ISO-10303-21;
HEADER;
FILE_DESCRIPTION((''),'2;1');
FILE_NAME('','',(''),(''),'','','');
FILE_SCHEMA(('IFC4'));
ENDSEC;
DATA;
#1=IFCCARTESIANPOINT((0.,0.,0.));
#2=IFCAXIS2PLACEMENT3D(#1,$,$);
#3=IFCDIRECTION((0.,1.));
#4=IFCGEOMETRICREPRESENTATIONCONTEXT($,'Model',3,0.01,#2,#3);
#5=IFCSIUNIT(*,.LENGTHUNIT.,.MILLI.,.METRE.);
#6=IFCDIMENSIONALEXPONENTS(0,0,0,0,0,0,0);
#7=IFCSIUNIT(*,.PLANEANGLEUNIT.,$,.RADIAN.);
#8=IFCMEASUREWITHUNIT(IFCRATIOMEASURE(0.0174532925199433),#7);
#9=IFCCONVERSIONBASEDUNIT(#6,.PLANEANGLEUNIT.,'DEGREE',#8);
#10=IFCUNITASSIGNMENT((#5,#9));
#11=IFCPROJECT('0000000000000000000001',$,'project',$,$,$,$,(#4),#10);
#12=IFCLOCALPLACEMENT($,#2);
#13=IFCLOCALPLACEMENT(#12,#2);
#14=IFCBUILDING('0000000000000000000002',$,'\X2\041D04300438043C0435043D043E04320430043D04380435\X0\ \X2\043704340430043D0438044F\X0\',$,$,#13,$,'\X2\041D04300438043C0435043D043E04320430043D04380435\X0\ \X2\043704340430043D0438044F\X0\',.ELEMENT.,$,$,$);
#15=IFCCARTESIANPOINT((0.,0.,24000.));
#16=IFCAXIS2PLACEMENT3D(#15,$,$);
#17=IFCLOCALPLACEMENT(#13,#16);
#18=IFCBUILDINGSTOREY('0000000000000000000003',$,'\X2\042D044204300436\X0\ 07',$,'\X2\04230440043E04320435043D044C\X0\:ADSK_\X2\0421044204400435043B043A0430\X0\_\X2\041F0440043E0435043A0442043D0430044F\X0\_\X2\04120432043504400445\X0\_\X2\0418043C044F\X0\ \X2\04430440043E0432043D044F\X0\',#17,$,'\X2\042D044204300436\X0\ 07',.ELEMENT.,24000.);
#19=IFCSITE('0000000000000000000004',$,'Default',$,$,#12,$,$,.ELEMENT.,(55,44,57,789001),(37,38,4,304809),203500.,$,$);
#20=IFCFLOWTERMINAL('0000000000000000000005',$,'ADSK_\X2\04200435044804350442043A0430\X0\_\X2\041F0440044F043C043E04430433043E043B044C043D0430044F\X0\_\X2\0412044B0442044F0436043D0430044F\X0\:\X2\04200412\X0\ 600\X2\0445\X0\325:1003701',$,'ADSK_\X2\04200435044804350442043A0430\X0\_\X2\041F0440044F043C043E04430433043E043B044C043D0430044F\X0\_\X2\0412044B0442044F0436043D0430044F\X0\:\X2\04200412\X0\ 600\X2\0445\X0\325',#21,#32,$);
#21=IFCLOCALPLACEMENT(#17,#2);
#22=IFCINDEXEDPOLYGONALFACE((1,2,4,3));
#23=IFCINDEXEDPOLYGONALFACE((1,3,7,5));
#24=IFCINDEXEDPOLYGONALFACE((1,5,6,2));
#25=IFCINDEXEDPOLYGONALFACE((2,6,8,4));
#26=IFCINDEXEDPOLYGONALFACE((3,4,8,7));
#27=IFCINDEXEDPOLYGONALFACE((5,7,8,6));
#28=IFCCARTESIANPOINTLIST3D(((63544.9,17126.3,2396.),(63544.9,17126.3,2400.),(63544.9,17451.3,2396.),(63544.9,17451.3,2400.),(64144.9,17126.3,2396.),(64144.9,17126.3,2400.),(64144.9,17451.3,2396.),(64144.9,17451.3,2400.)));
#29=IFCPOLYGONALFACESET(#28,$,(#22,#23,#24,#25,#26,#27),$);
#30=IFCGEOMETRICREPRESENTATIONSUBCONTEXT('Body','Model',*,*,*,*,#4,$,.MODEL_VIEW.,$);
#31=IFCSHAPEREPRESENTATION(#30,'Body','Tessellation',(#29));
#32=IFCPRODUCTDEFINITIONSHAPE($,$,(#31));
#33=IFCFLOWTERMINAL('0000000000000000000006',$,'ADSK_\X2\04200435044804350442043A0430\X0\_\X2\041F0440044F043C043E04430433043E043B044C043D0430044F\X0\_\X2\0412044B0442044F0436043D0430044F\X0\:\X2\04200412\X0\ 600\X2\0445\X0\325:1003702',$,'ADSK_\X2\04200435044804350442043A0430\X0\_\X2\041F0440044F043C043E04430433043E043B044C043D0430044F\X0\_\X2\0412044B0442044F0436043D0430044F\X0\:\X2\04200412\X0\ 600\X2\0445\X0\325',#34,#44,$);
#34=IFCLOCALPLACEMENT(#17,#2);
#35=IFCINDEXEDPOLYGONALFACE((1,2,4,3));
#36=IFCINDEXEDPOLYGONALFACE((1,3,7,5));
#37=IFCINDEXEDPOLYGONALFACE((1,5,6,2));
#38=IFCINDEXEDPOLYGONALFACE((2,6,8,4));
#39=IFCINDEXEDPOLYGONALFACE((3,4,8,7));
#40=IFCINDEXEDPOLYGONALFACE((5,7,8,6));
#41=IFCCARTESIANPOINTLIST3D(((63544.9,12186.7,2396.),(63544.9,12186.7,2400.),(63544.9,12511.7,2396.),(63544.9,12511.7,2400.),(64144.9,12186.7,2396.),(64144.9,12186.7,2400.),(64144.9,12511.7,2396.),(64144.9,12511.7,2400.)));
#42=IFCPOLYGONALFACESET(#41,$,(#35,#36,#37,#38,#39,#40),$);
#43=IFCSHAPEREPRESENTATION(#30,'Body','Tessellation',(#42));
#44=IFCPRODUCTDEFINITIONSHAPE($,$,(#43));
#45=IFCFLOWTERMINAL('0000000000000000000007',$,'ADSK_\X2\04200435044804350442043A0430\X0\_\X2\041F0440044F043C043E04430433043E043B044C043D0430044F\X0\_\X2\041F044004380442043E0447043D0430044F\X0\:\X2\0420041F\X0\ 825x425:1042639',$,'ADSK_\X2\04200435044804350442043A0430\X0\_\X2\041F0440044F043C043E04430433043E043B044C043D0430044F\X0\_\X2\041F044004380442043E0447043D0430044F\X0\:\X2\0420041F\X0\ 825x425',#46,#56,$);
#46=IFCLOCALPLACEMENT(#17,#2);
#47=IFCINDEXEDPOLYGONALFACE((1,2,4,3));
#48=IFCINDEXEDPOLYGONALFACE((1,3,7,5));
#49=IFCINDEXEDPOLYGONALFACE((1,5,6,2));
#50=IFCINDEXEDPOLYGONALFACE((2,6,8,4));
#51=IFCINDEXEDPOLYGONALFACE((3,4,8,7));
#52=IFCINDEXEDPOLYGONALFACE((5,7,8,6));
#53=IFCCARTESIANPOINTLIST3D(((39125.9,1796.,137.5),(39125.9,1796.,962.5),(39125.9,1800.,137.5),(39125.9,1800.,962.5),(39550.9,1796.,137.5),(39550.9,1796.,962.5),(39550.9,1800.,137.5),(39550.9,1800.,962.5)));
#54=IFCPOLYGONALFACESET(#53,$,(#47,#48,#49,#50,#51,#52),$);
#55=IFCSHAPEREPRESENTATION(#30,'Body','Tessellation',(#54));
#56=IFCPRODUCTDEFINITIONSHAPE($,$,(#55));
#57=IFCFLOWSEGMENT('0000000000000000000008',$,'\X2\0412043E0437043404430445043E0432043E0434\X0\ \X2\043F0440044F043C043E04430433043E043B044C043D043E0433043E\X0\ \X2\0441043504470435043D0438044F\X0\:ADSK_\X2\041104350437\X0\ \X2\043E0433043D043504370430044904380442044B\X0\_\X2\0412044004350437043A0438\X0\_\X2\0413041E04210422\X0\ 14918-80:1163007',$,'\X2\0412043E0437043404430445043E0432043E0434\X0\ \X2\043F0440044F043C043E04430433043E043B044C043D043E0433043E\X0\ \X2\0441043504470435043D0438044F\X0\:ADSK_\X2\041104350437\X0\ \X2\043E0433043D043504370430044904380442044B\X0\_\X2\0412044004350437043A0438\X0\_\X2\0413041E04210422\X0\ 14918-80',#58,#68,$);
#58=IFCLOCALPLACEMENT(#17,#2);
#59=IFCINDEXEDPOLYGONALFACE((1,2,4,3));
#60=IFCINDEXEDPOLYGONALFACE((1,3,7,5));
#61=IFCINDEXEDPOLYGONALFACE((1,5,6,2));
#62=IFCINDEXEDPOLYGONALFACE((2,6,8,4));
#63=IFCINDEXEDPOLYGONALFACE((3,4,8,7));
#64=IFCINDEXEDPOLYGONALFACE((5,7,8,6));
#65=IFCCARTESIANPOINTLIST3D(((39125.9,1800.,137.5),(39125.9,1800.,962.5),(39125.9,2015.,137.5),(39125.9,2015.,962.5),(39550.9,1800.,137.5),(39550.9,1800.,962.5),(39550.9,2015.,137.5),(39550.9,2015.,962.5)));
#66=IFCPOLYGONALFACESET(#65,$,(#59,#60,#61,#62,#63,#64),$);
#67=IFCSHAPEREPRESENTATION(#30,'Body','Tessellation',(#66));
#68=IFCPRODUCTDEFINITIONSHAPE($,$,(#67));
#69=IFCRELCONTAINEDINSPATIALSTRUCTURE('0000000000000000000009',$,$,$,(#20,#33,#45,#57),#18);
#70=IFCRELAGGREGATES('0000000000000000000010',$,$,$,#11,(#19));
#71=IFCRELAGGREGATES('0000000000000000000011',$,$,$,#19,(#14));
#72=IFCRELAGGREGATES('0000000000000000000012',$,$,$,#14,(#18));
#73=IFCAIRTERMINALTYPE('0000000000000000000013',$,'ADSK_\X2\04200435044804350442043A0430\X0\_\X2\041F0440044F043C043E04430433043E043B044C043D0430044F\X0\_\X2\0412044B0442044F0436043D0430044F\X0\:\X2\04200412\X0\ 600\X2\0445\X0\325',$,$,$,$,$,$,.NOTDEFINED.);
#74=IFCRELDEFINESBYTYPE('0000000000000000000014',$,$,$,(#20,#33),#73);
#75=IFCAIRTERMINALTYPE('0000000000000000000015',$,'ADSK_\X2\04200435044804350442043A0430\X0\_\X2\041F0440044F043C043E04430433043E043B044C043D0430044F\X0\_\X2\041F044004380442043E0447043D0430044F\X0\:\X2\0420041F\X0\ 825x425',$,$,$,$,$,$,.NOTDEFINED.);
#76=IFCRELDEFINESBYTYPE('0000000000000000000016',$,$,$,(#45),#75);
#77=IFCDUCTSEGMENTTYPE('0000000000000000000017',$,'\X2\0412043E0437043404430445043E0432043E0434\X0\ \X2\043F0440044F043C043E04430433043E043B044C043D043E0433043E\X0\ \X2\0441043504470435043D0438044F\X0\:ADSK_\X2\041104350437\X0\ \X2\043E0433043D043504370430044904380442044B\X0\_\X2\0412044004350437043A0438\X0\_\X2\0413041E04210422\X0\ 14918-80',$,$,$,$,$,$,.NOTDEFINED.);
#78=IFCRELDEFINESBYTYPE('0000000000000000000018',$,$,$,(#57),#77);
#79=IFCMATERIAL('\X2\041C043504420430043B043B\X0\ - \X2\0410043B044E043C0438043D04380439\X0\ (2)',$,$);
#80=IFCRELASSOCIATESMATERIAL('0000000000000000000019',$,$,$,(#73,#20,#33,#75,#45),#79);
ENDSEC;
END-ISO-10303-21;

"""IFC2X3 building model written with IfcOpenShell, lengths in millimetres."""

from ifc_helpers import new_model, entity, si_unit, converted_unit, direction, frame, frame_2d, origin, origin_2d_with_axis, place, context, subcontext, project, spatial, rectangle, extrude, source, transform, mapped, material, type_object, type_shapes, element, save


model = new_model("IFC2X3")

# Units and contexts
model_context = context("Model", 3, precision=0.01, world=origin(), true_north=direction((0.0, 1.0)))
body_context = subcontext(model_context, "Body", "Model", "MODEL_VIEW")
ifc_project = project(units=[si_unit("LENGTHUNIT", "METRE", prefix="MILLI"), converted_unit("PLANEANGLEUNIT", "DEGREE", entity("IfcRatioMeasure", 0.0174532925199433), si_unit("PLANEANGLEUNIT", "RADIAN"), dimensions=[0, 0, 0, 0, 0, 0, 0])], contexts=[model_context])

# Site, building, storey
site_placement = place(None, frame((0.0, 0.0, 0.0)))
site = spatial("IfcSite", under=ifc_project, at=site_placement, Name="Default", CompositionType="ELEMENT", RefLatitude=(55, 44, 57, 789001), RefLongitude=(37, 38, 4, 304809), RefElevation=203500.0)
building_placement = place(site_placement, origin())
building = spatial("IfcBuilding", under=site, at=building_placement, Name="Наименование здания", LongName="Наименование здания", CompositionType="ELEMENT")
storey_placement = place(building_placement, frame((0.0, 0.0, 24000.0)))
storey = spatial("IfcBuildingStorey", under=building, at=storey_placement, Name="Этаж 07", ObjectType="Уровень:ADSK_Стрелка_Проектная_Вверх_Имя уровня", LongName="Этаж 07", CompositionType="ELEMENT", Elevation=24000.0)

# Shared definitions
ifc_material_1 = material(Name="Металл - Алюминий (2)")

# Flow terminals
air_terminal_type_1 = type_object("IfcAirTerminalType", Name="ADSK_Решетка_Прямоугольная_Вытяжная:РВ 600х325", PredefinedType="NOTDEFINED", material=ifc_material_1)
shared_shape_1 = source(origin(), body_context, "Body", "SweptSolid", [
    extrude(rectangle(XDim=4.0, YDim=600.0, at=origin_2d_with_axis()), frame((0.0, -2.0, -162.5), z_axis=(0.0, 0.0, 1.0), x_axis=(0.0, 1.0, 0.0)), (0.0, 0.0, 1.0), 325.0),
])
type_shapes(air_terminal_type_1, [shared_shape_1])
for number, where, z_axis, x_axis, name in (
    (1, (63844.9, 17288.8, 2400.0), (0.0, -1.0, 0.0), (1.0, 0.0, 0.0), "ADSK_Решетка_Прямоугольная_Вытяжная:РВ 600х325:1003701"),
    (2, (63844.9, 12349.2, 2400.0), (0.0, -1.0, 0.0), (1.0, 0.0, 0.0), "ADSK_Решетка_Прямоугольная_Вытяжная:РВ 600х325:1003702"),
):
    element("IfcFlowTerminal", number, at=place(storey_placement, frame(where, z_axis=z_axis, x_axis=x_axis)), inside=storey, type_object=air_terminal_type_1, material=ifc_material_1, Name=name, ObjectType="ADSK_Решетка_Прямоугольная_Вытяжная:РВ 600х325", context=body_context, shape_type="MappedRepresentation", body=[
        mapped(shared_shape_1, transform((0.0, 0.0, 0.0), scale=1.0)),
    ])
air_terminal_type_2 = type_object("IfcAirTerminalType", Name="ADSK_Решетка_Прямоугольная_Приточная:РП 825x425", PredefinedType="NOTDEFINED", material=ifc_material_1)
shared_shape_2 = source(origin(), body_context, "Body", "SweptSolid", [
    extrude(rectangle(XDim=4.0, YDim=825.0, at=origin_2d_with_axis()), frame((0.0, -2.0, -212.5), z_axis=(0.0, 0.0, 1.0), x_axis=(0.0, 1.0, 0.0)), (0.0, 0.0, 1.0), 425.0),
])
type_shapes(air_terminal_type_2, [shared_shape_2])
flow_terminal_1_placement = place(storey_placement, frame((39338.4, 1800.0, 550.0), z_axis=(1.0, 0.0, 0.0), x_axis=(0.0, 0.0, -1.0)))
element("IfcFlowTerminal", 3, at=flow_terminal_1_placement, inside=storey, type_object=air_terminal_type_2, material=ifc_material_1, Name="ADSK_Решетка_Прямоугольная_Приточная:РП 825x425:1042639", ObjectType="ADSK_Решетка_Прямоугольная_Приточная:РП 825x425", context=body_context, shape_type="MappedRepresentation", body=[
    mapped(shared_shape_2, transform((0.0, 0.0, 0.0), scale=1.0)),
])

# Flow segment
duct_segment_type_1 = type_object("IfcDuctSegmentType", Name="Воздуховод прямоугольного сечения:ADSK_Без огнезащиты_Врезки_ГОСТ 14918-80", PredefinedType="NOTDEFINED")
flow_segment_1_placement = place(storey_placement, frame((39125.9, 1800.0, 137.5)))
element("IfcFlowSegment", 4, at=flow_segment_1_placement, inside=storey, type_object=duct_segment_type_1, Name="Воздуховод прямоугольного сечения:ADSK_Без огнезащиты_Врезки_ГОСТ 14918-80:1163007", ObjectType="Воздуховод прямоугольного сечения:ADSK_Без огнезащиты_Врезки_ГОСТ 14918-80", context=body_context, shape_type="SweptSolid", body=[
    extrude(rectangle(XDim=215.0, YDim=425.0, at=frame_2d((0.0, 0.0), x_axis=(1.0, 0.0))), frame((212.5, 107.5, 0.0), z_axis=(0.0, 0.0, 1.0), x_axis=(0.0, 1.0, 0.0)), (0.0, 0.0, 1.0), 825.0),
])

save(model, "model.ifc")
